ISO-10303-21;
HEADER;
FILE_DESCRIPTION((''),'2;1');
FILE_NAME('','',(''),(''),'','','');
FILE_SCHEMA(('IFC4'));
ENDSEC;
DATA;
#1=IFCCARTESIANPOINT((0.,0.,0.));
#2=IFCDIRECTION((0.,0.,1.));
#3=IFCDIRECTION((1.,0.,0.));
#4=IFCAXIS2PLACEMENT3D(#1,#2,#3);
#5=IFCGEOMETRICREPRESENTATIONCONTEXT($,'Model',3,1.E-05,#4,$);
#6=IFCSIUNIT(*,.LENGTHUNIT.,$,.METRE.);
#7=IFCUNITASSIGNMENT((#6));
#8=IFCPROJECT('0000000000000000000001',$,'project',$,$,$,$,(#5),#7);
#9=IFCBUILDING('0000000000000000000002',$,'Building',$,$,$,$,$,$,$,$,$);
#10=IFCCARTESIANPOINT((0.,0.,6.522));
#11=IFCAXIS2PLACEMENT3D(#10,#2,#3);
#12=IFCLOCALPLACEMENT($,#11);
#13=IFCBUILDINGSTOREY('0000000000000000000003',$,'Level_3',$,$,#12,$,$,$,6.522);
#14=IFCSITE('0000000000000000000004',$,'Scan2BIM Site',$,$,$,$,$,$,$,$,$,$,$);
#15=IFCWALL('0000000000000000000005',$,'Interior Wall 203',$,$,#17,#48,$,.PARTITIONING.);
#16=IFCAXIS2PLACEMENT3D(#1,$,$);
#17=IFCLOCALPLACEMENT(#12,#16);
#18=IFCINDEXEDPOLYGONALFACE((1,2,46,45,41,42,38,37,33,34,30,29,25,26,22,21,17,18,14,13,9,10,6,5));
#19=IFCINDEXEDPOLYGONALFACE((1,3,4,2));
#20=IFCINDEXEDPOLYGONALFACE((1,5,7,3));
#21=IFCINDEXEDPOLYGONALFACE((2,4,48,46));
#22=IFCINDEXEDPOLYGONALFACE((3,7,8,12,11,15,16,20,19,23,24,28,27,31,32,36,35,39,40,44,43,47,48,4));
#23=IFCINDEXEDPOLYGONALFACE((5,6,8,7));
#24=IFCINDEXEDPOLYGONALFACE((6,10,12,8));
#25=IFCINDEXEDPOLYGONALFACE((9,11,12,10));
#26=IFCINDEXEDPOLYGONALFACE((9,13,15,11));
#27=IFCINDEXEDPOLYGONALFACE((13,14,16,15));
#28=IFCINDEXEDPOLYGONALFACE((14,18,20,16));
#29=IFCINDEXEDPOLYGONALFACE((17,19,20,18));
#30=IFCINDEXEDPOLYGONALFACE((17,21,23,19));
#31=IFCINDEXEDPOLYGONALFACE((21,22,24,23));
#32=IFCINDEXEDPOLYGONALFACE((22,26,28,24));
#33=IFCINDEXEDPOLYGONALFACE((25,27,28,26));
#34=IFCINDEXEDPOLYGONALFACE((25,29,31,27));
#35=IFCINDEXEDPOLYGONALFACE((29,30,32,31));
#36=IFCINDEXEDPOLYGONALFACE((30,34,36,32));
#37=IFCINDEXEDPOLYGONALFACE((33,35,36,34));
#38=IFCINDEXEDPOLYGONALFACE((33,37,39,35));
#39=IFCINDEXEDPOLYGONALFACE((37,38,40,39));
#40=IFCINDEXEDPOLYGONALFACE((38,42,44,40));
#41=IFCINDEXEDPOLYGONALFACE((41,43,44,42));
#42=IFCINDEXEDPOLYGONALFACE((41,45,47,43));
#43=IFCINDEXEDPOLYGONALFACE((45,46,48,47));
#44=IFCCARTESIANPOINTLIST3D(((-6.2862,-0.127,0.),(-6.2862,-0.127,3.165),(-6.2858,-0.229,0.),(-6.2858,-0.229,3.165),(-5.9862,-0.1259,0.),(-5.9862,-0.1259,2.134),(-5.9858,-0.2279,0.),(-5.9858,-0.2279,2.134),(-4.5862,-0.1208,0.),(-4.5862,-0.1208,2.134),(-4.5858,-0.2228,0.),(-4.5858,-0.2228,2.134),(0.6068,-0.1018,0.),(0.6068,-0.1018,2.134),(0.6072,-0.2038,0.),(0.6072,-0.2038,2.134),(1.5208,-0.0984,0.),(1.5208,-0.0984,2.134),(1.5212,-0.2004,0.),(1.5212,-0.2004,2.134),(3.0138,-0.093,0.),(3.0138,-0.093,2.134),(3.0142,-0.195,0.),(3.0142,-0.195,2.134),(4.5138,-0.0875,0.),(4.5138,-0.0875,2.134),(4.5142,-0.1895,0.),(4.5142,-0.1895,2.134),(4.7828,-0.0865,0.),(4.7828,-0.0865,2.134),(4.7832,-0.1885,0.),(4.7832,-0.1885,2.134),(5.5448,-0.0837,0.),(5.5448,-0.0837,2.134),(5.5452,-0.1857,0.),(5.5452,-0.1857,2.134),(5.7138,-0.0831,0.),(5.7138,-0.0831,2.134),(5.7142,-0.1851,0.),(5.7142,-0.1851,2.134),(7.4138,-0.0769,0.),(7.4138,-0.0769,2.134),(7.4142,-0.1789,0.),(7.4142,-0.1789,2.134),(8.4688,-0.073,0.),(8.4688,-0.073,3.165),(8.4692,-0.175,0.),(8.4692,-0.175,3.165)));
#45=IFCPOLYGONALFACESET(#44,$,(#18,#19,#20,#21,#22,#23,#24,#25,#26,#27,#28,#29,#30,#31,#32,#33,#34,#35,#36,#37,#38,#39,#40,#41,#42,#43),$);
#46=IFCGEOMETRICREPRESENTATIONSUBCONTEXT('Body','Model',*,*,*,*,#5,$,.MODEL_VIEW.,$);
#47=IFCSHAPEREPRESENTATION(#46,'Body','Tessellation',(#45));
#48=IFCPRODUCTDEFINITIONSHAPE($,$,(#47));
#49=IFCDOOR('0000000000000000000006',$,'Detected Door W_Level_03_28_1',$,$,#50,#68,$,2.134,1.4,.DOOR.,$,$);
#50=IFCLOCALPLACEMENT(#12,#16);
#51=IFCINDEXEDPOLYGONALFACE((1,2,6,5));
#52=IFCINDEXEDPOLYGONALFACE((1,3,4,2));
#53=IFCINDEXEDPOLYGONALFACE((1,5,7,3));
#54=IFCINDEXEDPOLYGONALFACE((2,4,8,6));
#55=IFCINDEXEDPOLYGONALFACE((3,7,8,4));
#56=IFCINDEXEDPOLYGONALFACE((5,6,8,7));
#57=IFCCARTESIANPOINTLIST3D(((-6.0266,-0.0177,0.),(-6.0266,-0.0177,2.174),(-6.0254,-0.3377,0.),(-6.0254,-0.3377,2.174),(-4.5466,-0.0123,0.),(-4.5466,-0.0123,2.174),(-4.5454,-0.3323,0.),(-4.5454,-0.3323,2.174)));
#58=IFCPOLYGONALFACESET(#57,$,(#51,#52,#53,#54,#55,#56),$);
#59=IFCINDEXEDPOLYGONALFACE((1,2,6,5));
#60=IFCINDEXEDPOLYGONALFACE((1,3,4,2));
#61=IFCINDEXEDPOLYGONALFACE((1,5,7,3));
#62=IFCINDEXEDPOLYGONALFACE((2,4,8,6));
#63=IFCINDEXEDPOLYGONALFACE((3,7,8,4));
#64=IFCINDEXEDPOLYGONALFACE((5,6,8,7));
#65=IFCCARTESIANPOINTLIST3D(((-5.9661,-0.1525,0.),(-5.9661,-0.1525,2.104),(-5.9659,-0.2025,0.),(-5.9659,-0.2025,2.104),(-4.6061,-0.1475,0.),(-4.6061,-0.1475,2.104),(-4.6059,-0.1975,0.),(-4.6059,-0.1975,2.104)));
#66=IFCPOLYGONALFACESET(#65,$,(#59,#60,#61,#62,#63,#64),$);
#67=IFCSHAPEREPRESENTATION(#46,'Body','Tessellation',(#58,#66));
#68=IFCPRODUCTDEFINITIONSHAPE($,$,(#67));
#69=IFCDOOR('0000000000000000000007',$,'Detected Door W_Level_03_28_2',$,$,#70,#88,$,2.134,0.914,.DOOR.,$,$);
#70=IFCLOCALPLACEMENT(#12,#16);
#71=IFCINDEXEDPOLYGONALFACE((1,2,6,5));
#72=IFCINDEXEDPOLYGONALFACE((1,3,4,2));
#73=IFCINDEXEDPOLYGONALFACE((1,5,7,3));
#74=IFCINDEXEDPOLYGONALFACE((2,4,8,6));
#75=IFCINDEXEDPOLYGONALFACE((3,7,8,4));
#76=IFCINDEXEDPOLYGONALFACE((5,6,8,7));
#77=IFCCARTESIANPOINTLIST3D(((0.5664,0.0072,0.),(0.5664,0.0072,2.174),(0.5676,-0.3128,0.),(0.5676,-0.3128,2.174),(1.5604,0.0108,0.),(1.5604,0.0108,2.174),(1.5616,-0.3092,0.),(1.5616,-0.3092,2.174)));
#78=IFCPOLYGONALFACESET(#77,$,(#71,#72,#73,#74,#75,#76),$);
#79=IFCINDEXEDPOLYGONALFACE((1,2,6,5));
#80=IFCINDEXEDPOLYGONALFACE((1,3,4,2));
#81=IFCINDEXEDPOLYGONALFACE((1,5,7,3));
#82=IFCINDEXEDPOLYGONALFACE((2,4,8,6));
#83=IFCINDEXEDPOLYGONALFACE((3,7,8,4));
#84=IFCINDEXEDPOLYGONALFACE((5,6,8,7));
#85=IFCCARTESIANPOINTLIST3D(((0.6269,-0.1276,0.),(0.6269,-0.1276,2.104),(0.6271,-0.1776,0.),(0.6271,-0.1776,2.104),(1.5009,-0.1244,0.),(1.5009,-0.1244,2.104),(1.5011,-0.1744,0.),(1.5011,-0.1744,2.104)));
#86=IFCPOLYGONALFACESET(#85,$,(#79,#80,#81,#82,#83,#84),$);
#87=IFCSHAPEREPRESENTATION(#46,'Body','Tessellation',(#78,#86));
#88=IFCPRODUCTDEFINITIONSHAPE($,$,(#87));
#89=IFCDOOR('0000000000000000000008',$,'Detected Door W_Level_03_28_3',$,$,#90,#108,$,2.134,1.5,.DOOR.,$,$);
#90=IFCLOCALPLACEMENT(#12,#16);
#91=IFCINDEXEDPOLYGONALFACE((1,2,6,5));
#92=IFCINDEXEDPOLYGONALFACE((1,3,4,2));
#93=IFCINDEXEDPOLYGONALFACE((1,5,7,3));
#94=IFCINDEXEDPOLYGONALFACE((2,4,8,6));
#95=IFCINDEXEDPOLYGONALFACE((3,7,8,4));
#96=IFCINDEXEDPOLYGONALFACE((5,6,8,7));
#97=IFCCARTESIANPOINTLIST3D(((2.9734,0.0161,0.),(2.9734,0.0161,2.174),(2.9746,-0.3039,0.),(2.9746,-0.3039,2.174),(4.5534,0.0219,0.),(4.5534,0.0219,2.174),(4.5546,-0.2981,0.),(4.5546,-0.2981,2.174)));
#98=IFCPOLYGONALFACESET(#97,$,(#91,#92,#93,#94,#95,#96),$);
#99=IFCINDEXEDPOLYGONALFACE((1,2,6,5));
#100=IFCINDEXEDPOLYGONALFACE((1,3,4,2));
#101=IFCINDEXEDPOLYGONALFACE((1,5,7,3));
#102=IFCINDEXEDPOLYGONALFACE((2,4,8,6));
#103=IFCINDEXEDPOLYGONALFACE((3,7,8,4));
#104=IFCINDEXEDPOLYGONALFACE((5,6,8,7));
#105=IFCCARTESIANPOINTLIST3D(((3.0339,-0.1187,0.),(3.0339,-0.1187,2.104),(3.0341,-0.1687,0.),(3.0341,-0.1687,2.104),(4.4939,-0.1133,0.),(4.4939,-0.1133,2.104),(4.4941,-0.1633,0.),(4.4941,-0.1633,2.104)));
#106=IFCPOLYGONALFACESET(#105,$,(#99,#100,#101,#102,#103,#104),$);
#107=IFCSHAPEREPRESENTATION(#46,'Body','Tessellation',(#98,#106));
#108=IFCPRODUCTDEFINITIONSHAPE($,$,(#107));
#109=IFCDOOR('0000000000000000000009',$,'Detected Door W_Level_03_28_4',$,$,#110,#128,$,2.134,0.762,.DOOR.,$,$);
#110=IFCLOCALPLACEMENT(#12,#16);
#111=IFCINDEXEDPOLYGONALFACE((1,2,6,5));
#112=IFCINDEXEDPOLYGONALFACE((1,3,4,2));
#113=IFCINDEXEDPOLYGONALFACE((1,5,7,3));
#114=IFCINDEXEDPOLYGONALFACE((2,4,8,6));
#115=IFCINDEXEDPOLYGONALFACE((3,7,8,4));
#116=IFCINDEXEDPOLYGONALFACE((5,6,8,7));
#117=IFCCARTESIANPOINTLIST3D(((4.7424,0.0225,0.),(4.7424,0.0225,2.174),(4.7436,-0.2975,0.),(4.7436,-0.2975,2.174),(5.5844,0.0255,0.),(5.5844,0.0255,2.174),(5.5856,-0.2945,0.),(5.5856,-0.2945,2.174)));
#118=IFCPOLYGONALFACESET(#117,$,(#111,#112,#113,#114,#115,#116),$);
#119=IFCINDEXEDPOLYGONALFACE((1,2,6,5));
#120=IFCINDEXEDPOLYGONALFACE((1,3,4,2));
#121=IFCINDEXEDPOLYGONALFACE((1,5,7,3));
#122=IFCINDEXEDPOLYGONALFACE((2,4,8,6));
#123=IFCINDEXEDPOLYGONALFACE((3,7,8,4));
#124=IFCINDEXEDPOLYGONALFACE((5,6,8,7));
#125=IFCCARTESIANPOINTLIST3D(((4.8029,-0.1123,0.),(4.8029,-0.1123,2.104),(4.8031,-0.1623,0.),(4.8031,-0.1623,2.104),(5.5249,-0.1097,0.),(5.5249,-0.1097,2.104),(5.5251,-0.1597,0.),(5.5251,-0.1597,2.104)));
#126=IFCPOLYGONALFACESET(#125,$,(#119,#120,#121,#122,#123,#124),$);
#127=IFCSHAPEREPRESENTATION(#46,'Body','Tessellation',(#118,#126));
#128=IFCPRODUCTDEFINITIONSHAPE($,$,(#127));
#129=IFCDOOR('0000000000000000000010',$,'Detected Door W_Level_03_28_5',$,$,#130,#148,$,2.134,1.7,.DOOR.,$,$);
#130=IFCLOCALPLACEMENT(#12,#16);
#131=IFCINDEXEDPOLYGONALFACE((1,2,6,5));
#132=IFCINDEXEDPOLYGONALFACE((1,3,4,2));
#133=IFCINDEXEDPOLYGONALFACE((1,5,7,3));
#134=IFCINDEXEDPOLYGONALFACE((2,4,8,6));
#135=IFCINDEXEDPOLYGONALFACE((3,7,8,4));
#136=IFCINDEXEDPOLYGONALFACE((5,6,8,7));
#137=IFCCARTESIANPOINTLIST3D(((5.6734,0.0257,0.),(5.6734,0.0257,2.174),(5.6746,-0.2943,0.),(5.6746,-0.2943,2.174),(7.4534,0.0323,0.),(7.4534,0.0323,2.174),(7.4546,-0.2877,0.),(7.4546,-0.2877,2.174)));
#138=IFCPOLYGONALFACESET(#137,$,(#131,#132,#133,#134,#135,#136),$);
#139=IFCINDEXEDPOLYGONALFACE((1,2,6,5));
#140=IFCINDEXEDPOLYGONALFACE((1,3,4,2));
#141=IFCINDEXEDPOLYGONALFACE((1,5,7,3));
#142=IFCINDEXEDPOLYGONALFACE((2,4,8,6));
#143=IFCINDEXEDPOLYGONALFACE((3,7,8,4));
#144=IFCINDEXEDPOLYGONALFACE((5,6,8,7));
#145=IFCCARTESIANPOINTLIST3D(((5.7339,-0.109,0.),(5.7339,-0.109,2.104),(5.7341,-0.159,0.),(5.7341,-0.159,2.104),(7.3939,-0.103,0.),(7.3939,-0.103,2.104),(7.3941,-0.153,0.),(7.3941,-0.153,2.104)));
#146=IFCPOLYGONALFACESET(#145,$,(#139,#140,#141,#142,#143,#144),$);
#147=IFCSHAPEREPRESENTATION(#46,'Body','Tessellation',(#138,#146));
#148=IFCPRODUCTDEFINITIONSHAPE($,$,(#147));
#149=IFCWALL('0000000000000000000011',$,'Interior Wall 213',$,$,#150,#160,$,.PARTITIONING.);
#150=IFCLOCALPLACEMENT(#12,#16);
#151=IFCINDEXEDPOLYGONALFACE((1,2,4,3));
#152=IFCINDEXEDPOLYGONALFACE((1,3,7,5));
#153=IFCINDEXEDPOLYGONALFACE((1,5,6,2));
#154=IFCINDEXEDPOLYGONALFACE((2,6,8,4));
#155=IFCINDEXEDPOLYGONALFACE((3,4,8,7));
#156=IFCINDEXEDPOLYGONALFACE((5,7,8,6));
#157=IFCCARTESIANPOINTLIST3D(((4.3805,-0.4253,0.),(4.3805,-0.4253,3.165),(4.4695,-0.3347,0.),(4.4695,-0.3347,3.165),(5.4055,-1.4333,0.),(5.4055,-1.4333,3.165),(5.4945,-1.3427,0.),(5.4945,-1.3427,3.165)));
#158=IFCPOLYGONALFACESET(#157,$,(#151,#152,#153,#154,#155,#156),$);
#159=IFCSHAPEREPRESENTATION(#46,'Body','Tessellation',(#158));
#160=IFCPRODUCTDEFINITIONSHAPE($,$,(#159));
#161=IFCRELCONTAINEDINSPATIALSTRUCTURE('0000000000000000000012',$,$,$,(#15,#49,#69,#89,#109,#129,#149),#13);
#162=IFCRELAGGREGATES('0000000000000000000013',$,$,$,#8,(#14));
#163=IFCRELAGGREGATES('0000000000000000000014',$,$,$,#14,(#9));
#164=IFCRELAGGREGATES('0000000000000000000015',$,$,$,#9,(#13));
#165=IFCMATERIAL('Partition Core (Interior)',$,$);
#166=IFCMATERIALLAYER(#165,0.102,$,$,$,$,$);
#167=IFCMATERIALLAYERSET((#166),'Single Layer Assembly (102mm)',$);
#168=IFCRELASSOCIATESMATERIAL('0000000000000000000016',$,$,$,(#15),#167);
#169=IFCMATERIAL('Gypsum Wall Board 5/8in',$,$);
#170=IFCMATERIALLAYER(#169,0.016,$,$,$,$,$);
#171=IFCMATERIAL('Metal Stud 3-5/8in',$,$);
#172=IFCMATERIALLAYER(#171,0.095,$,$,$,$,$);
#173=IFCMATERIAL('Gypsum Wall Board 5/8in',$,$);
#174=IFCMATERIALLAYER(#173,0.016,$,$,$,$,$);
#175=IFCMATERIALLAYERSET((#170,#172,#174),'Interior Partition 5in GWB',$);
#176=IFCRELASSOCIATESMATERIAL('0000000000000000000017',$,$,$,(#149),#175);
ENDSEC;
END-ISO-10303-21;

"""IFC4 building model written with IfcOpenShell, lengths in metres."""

from ifc_helpers import new_model, si_unit, frame, origin, origin_with_axes, place, context, subcontext, project, spatial, rectangle, extrude, material, layer, layer_set, element, fill, save


model = new_model("IFC4")

# Units and contexts
model_context = context("Model", 3, precision=1e-05, world=origin_with_axes())
body_context = subcontext(model_context, "Body", "Model", "MODEL_VIEW")
ifc_project = project(units=[si_unit("LENGTHUNIT", "METRE")], contexts=[model_context])

# Site, building, storey
site = spatial("IfcSite", under=ifc_project, Name="Scan2BIM Site")
building = spatial("IfcBuilding", under=site, Name="Building")
storey_placement = place(None, frame((0.0, 0.0, 6.522), z_axis=(0.0, 0.0, 1.0), x_axis=(1.0, 0.0, 0.0)))
storey = spatial("IfcBuildingStorey", under=building, at=storey_placement, Name="Level_3", Elevation=6.522)

# Wall, openings, doors
ifc_material_1 = material(Name="Partition Core (Interior)")
ifc_layer_1 = layer(ifc_material_1, 0.102)
ifc_layer_set_1 = layer_set([ifc_layer_1], Name="Single Layer Assembly (102mm)")
wall_1_placement = place(storey_placement, frame((1.0915, -0.151, 0.0), z_axis=(0.0, 0.0, 1.0), x_axis=(0.999993, 0.00366, 0.0)))
wall_1 = element("IfcWall", 1, at=wall_1_placement, inside=storey, material=ifc_layer_set_1, Name="Interior Wall 203", PredefinedType="PARTITIONING", context=body_context, shape_type="SweptSolid", body=[
    extrude(rectangle(XDim=14.7551, YDim=0.102), origin(), (0.0, 0.0, 1.0), 3.165),
])
opening_1_placement = place(None, frame((-5.286, -0.175, 6.522), z_axis=(0.0, 0.0, 1.0), x_axis=(0.999993, 0.00366, 0.0)))
opening_1 = element("IfcOpeningElement", 2, at=opening_1_placement, cuts=wall_1, PredefinedType="OPENING", context=body_context, shape_type="SweptSolid", body=[
    extrude(rectangle(XDim=1.4, YDim=0.202), origin(), (0.0, 0.0, 1.0), 2.134),
])
opening_2_placement = place(None, frame((1.064, -0.151, 6.522), z_axis=(0.0, 0.0, 1.0), x_axis=(0.999993, 0.00366, 0.0)))
opening_2 = element("IfcOpeningElement", 3, at=opening_2_placement, cuts=wall_1, PredefinedType="OPENING", context=body_context, shape_type="SweptSolid", body=[
    extrude(rectangle(XDim=0.914, YDim=0.202), origin(), (0.0, 0.0, 1.0), 2.134),
])
opening_3_placement = place(None, frame((3.764, -0.141, 6.522), z_axis=(0.0, 0.0, 1.0), x_axis=(0.999993, 0.00366, 0.0)))
opening_3 = element("IfcOpeningElement", 4, at=opening_3_placement, cuts=wall_1, PredefinedType="OPENING", context=body_context, shape_type="SweptSolid", body=[
    extrude(rectangle(XDim=1.5, YDim=0.202), origin(), (0.0, 0.0, 1.0), 2.134),
])
opening_4_placement = place(None, frame((5.164, -0.136, 6.522), z_axis=(0.0, 0.0, 1.0), x_axis=(0.999993, 0.00366, 0.0)))
opening_4 = element("IfcOpeningElement", 5, at=opening_4_placement, cuts=wall_1, PredefinedType="OPENING", context=body_context, shape_type="SweptSolid", body=[
    extrude(rectangle(XDim=0.762, YDim=0.202), origin(), (0.0, 0.0, 1.0), 2.134),
])
opening_5_placement = place(None, frame((6.564, -0.131, 6.522), z_axis=(0.0, 0.0, 1.0), x_axis=(0.999993, 0.00366, 0.0)))
opening_5 = element("IfcOpeningElement", 6, at=opening_5_placement, cuts=wall_1, PredefinedType="OPENING", context=body_context, shape_type="SweptSolid", body=[
    extrude(rectangle(XDim=1.7, YDim=0.202), origin(), (0.0, 0.0, 1.0), 2.134),
])
door_1_placement = place(opening_1_placement, frame((0.0, 0.0, 0.0), z_axis=(0.0, 0.0, 1.0), x_axis=(1.0, 0.0, 0.0)))
door_1 = element("IfcDoor", 7, at=door_1_placement, inside=storey, Name="Detected Door W_Level_03_28_1", OverallHeight=2.134, OverallWidth=1.4, PredefinedType="DOOR", context=body_context, shape_type="SweptSolid", body=[
    extrude(rectangle(XDim=1.48, YDim=0.32), origin(), (0.0, 0.0, 1.0), 2.174),
    extrude(rectangle(XDim=1.36, YDim=0.05), origin(), (0.0, 0.0, 1.0), 2.104),
])
fill(opening_1, door_1)
door_2_placement = place(opening_2_placement, frame((0.0, 0.0, 0.0), z_axis=(0.0, 0.0, 1.0), x_axis=(1.0, 0.0, 0.0)))
door_2 = element("IfcDoor", 8, at=door_2_placement, inside=storey, Name="Detected Door W_Level_03_28_2", OverallHeight=2.134, OverallWidth=0.914, PredefinedType="DOOR", context=body_context, shape_type="SweptSolid", body=[
    extrude(rectangle(XDim=0.994, YDim=0.32), origin(), (0.0, 0.0, 1.0), 2.174),
    extrude(rectangle(XDim=0.874, YDim=0.05), origin(), (0.0, 0.0, 1.0), 2.104),
])
fill(opening_2, door_2)
door_3_placement = place(opening_3_placement, frame((0.0, 0.0, 0.0), z_axis=(0.0, 0.0, 1.0), x_axis=(1.0, 0.0, 0.0)))
door_3 = element("IfcDoor", 9, at=door_3_placement, inside=storey, Name="Detected Door W_Level_03_28_3", OverallHeight=2.134, OverallWidth=1.5, PredefinedType="DOOR", context=body_context, shape_type="SweptSolid", body=[
    extrude(rectangle(XDim=1.58, YDim=0.32), origin(), (0.0, 0.0, 1.0), 2.174),
    extrude(rectangle(XDim=1.46, YDim=0.05), origin(), (0.0, 0.0, 1.0), 2.104),
])
fill(opening_3, door_3)
door_4_placement = place(opening_4_placement, frame((0.0, 0.0, 0.0), z_axis=(0.0, 0.0, 1.0), x_axis=(1.0, 0.0, 0.0)))
door_4 = element("IfcDoor", 10, at=door_4_placement, inside=storey, Name="Detected Door W_Level_03_28_4", OverallHeight=2.134, OverallWidth=0.762, PredefinedType="DOOR", context=body_context, shape_type="SweptSolid", body=[
    extrude(rectangle(XDim=0.842, YDim=0.32), origin(), (0.0, 0.0, 1.0), 2.174),
    extrude(rectangle(XDim=0.722, YDim=0.05), origin(), (0.0, 0.0, 1.0), 2.104),
])
fill(opening_4, door_4)
door_5_placement = place(opening_5_placement, frame((0.0, 0.0, 0.0), z_axis=(0.0, 0.0, 1.0), x_axis=(1.0, 0.0, 0.0)))
door_5 = element("IfcDoor", 11, at=door_5_placement, inside=storey, Name="Detected Door W_Level_03_28_5", OverallHeight=2.134, OverallWidth=1.7, PredefinedType="DOOR", context=body_context, shape_type="SweptSolid", body=[
    extrude(rectangle(XDim=1.78, YDim=0.32), origin(), (0.0, 0.0, 1.0), 2.174),
    extrude(rectangle(XDim=1.66, YDim=0.05), origin(), (0.0, 0.0, 1.0), 2.104),
])
fill(opening_5, door_5)

# Wall
ifc_material_2 = material(Name="Gypsum Wall Board 5/8in")
ifc_layer_2 = layer(ifc_material_2, 0.016)
ifc_material_3 = material(Name="Metal Stud 3-5/8in")
ifc_layer_3 = layer(ifc_material_3, 0.095)
ifc_material_4 = material(Name="Gypsum Wall Board 5/8in")
ifc_layer_4 = layer(ifc_material_4, 0.016)
ifc_layer_set_2 = layer_set([ifc_layer_2, ifc_layer_3, ifc_layer_4], Name="Interior Partition 5in GWB")
wall_2_placement = place(storey_placement, frame((4.9375, -0.884, 0.0), z_axis=(0.0, 0.0, 1.0), x_axis=(-0.712995, 0.701169, 0.0)))
element("IfcWall", 12, at=wall_2_placement, inside=storey, material=ifc_layer_set_2, Name="Interior Wall 213", PredefinedType="PARTITIONING", context=body_context, shape_type="SweptSolid", body=[
    extrude(rectangle(XDim=1.4376, YDim=0.127), origin(), (0.0, 0.0, 1.0), 3.165),
])

save(model, "model.ifc")
